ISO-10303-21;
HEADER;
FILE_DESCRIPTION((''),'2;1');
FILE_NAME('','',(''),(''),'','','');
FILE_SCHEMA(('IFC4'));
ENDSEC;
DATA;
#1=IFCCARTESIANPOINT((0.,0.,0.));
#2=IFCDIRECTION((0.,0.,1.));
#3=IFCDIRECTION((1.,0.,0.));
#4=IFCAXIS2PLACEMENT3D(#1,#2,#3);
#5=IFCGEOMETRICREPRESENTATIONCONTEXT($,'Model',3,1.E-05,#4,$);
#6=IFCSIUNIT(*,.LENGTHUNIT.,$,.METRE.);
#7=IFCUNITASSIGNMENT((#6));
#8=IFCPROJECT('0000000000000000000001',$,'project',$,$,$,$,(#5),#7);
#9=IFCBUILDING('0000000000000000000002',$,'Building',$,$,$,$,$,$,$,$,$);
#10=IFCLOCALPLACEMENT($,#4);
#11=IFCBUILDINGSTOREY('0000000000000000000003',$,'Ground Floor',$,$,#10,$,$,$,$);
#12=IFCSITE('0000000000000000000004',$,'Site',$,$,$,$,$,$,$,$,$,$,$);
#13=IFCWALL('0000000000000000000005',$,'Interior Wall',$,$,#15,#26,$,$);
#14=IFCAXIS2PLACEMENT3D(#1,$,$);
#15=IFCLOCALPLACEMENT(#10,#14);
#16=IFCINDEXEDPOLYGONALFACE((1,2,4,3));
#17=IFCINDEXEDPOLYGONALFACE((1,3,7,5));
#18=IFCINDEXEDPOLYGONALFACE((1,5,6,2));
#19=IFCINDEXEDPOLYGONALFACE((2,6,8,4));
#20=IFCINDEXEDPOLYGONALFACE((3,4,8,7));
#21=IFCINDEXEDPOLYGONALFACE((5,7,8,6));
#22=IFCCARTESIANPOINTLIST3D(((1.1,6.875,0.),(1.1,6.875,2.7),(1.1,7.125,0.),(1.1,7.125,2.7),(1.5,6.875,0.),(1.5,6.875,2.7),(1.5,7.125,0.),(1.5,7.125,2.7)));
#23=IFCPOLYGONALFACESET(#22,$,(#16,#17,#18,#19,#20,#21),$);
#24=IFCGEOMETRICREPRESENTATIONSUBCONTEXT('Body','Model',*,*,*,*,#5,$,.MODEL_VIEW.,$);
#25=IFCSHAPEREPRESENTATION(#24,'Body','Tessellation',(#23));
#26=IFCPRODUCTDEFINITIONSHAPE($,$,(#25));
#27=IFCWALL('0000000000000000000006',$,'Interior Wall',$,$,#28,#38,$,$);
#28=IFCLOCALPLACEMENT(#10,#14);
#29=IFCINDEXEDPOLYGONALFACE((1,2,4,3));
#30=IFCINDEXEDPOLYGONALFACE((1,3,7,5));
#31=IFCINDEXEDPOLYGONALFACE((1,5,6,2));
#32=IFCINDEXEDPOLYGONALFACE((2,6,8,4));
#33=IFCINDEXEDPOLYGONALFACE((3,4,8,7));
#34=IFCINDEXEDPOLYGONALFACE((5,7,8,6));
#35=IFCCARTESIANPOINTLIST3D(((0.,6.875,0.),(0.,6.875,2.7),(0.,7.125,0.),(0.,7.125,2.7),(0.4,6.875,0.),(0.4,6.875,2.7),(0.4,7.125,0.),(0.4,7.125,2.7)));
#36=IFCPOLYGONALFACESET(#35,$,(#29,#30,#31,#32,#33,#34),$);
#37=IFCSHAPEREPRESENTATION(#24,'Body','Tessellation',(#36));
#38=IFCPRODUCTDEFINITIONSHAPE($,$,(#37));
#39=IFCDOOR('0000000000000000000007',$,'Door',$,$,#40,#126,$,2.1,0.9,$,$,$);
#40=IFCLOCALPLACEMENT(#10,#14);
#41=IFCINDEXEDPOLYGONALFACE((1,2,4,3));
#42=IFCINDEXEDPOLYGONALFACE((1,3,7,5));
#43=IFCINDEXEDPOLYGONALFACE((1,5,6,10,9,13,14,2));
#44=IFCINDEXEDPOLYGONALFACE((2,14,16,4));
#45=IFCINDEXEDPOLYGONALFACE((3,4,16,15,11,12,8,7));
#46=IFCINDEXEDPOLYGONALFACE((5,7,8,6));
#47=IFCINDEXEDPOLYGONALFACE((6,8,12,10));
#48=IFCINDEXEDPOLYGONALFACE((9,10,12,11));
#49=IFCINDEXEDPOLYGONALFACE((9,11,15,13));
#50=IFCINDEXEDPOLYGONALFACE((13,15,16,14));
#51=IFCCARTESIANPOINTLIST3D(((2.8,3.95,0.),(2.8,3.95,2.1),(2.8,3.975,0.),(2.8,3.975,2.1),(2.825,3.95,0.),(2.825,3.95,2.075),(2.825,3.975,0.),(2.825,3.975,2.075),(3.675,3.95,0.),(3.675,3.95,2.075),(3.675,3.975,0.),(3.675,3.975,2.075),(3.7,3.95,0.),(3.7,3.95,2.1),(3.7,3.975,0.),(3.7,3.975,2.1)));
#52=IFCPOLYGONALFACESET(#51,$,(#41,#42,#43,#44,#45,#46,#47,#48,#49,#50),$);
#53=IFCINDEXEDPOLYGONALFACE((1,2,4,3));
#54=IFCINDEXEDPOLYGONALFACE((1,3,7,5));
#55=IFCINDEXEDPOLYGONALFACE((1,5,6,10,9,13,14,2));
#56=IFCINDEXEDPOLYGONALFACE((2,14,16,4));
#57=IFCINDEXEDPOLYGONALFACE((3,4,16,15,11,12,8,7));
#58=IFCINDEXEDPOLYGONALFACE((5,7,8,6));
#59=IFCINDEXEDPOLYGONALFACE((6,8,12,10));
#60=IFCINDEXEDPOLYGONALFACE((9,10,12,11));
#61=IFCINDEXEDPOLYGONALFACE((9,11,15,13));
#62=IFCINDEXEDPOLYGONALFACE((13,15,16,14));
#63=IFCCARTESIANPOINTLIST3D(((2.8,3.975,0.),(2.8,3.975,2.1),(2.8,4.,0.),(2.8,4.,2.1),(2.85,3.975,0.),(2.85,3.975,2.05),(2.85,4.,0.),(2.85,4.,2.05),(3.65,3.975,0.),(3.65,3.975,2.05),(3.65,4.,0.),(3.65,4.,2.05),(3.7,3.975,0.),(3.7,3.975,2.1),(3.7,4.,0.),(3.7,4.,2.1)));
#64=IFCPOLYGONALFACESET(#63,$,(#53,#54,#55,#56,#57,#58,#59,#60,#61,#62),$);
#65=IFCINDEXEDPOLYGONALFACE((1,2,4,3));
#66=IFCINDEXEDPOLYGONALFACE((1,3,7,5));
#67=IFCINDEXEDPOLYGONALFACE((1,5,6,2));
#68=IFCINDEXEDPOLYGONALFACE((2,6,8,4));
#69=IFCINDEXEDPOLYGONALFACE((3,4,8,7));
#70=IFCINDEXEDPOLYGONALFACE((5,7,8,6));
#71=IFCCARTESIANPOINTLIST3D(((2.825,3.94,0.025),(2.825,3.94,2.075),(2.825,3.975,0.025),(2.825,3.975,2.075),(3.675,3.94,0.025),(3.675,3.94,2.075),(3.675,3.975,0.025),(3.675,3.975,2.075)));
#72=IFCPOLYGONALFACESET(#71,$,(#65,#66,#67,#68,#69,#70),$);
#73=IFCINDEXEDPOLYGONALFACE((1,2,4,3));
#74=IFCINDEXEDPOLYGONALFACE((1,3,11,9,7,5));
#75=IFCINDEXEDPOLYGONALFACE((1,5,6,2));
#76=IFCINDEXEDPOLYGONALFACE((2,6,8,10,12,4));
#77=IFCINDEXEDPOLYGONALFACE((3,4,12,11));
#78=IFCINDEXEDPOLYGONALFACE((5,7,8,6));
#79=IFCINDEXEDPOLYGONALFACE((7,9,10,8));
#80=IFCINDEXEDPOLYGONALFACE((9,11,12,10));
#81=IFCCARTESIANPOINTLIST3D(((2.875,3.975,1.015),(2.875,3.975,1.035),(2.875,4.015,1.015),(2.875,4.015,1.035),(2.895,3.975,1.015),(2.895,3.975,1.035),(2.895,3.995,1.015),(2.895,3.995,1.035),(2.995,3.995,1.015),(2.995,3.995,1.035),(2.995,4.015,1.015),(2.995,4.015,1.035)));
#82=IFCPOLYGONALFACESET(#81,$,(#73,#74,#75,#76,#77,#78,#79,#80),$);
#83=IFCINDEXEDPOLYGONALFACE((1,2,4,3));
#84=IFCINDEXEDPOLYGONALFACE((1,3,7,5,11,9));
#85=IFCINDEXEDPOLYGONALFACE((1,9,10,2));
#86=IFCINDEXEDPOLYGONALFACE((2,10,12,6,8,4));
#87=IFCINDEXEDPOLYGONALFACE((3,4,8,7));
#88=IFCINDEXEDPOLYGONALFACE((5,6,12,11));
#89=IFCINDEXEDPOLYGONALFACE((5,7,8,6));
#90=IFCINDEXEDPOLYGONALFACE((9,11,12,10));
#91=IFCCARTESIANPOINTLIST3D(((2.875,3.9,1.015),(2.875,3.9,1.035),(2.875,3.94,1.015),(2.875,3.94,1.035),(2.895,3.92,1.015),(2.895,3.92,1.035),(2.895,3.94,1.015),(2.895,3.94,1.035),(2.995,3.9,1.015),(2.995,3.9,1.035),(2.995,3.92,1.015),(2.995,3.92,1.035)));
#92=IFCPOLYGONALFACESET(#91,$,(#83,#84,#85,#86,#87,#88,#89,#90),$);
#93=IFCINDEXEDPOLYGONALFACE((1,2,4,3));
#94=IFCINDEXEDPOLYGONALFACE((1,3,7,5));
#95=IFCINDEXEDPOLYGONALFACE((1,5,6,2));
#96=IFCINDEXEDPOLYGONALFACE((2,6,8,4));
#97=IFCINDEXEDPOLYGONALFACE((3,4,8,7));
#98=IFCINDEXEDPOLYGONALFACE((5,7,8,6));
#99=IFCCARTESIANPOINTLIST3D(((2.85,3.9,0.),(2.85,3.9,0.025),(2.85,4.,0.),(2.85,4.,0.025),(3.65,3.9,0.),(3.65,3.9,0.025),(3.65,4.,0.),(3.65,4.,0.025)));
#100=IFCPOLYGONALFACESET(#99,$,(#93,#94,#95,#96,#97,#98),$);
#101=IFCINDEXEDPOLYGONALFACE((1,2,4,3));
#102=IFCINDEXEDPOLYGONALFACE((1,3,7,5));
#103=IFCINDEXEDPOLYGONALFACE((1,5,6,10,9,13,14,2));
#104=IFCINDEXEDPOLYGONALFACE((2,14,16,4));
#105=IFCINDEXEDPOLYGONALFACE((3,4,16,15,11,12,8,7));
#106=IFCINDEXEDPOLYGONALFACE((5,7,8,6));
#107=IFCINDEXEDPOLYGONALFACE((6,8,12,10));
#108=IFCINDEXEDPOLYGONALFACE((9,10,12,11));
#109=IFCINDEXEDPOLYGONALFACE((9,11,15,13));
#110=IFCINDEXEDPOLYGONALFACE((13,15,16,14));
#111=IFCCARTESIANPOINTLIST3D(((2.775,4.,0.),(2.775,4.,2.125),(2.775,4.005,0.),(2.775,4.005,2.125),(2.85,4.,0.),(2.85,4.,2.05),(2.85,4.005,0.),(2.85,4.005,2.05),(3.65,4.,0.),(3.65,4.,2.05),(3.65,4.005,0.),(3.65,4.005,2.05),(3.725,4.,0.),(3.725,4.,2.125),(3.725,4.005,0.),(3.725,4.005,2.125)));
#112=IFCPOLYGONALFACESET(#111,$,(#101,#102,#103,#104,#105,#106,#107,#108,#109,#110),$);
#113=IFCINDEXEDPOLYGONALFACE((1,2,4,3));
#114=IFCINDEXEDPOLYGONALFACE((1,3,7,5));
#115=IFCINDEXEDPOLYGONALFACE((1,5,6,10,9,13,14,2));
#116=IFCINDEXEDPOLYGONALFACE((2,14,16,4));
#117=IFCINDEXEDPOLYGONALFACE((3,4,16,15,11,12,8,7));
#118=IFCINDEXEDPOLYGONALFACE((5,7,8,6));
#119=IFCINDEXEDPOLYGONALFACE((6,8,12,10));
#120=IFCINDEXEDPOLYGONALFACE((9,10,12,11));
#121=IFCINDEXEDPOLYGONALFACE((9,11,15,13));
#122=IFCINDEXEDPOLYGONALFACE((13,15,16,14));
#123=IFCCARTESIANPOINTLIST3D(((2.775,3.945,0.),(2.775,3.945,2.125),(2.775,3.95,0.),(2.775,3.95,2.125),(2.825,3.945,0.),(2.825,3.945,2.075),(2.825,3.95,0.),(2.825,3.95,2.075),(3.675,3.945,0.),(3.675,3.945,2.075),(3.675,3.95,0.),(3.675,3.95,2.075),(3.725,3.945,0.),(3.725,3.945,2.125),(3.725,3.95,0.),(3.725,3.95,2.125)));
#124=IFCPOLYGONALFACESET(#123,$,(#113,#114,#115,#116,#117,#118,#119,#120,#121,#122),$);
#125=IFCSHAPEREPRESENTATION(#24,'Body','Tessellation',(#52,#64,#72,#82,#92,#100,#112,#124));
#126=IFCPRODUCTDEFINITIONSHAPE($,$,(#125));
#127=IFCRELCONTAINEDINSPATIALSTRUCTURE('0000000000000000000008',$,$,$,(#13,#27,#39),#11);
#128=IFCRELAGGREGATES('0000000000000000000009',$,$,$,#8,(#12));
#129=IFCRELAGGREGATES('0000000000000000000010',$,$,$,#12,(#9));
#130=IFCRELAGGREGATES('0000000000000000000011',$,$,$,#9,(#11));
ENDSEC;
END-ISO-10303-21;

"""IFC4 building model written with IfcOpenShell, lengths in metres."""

from ifc_helpers import new_model, si_unit, frame, origin_with_axes, place, context, subcontext, project, spatial, line, indexed_curve, outline, extrude, element, save


model = new_model("IFC4")

# Units and contexts
model_context = context("Model", 3, precision=1e-05, world=origin_with_axes())
body_context = subcontext(model_context, "Body", "Model", "MODEL_VIEW")
ifc_project = project(units=[si_unit("LENGTHUNIT", "METRE")], contexts=[model_context])

# Site, building, storey
site = spatial("IfcSite", under=ifc_project, Name="Site")
building = spatial("IfcBuilding", under=site, Name="Building")
storey_placement = place(None, origin_with_axes())
storey = spatial("IfcBuildingStorey", under=building, at=storey_placement, Name="Ground Floor")

# Walls
for number, where, z_axis, x_axis, name in (
    (1, (1.5, 7.0, 0.0), (0.0, 0.0, 1.0), (-1.0, 0.0, 0.0), "Interior Wall"),
    (2, (0.4, 7.0, 0.0), (0.0, 0.0, 1.0), (-1.0, 0.0, 0.0), "Interior Wall"),
):
    element("IfcWall", number, at=place(storey_placement, frame(where, z_axis=z_axis, x_axis=x_axis)), inside=storey, Name=name, context=body_context, shape_type="SweptSolid", body=[
        extrude(outline(indexed_curve([(0.0, 0.0), (0.0, 0.25), (0.4, 0.25), (0.4, 0.0), (0.0, 0.0)], self_intersect=False)), frame((0.0, -0.125, 0.0), z_axis=(0.0, 0.0, 1.0), x_axis=(1.0, 0.0, 0.0)), (0.0, 0.0, 1.0), 2.7),
    ])

# Door
door_1_placement = place(storey_placement, frame((3.7, 4.0, 0.0), z_axis=(0.0, 0.0, 1.0), x_axis=(-1.0, 0.0, 0.0)))
element("IfcDoor", 3, at=door_1_placement, inside=storey, Name="Door", OverallHeight=2.1, OverallWidth=0.9, context=body_context, shape_type="SweptSolid", body=[
    extrude(outline(indexed_curve([(0.0, 0.0), (0.0, 2.1), (0.9, 2.1), (0.9, 0.0), (0.875, 0.0), (0.875, 2.075), (0.025, 2.075), (0.025, 0.0)], segments=[line(1, 2, 3, 4, 5, 6, 7, 8, 1)])), frame((0.0, 0.025, 0.0), z_axis=(0.0, -1.0, 0.0), x_axis=(1.0, 0.0, 0.0)), (0.0, 0.0, -1.0), 0.025),
    extrude(outline(indexed_curve([(0.0, 0.0), (0.0, 2.1), (0.9, 2.1), (0.9, 0.0), (0.85, 0.0), (0.85, 2.05), (0.05, 2.05), (0.05, 0.0)], segments=[line(1, 2, 3, 4, 5, 6, 7, 8, 1)])), frame((0.0, 0.0, 0.0), z_axis=(0.0, -1.0, 0.0), x_axis=(1.0, 0.0, 0.0)), (0.0, 0.0, -1.0), 0.025),
    extrude(outline(indexed_curve([(0.0, 0.0), (0.85, 0.0), (0.85, 0.035), (0.0, 0.035)], segments=[line(1, 2, 3, 4, 1)])), frame((0.025, 0.025, 0.025), z_axis=(0.0, 0.0, 1.0), x_axis=(1.0, 0.0, 0.0)), (0.0, 0.0, 1.0), 2.05),
    extrude(outline(indexed_curve([(0.0, 0.0), (0.0, -0.04), (-0.12, -0.04), (-0.12, -0.02), (-0.02, -0.02), (-0.02, 0.0)], segments=[line(1, 2, 3, 4, 5, 6, 1)])), frame((0.825, 0.025, 1.015), z_axis=(0.0, 0.0, 1.0), x_axis=(1.0, 0.0, 0.0)), (0.0, 0.0, 1.0), 0.02),
    extrude(outline(indexed_curve([(0.0, 0.0), (0.0, 0.04), (-0.12, 0.04), (-0.12, 0.02), (-0.02, 0.02), (-0.02, 0.0)], segments=[line(1, 2, 3, 4, 5, 6, 1)])), frame((0.825, 0.06, 1.015), z_axis=(0.0, 0.0, 1.0), x_axis=(1.0, 0.0, 0.0)), (0.0, 0.0, 1.0), 0.02),
    extrude(outline(indexed_curve([(0.0, 0.0), (0.8, 0.0), (0.8, 0.1), (0.0, 0.1)], segments=[line(1, 2, 3, 4, 1)])), frame((0.05, 0.0, 0.0), z_axis=(0.0, 0.0, 1.0), x_axis=(1.0, 0.0, 0.0)), (0.0, 0.0, 1.0), 0.025),
    extrude(outline(indexed_curve([(0.0, 0.0), (0.0, 2.125), (0.95, 2.125), (0.95, 0.0), (0.875, 0.0), (0.875, 2.05), (0.075, 2.05), (0.075, 0.0)], segments=[line(1, 2, 3, 4, 5, 6, 7, 8, 1)])), frame((-0.025, -0.005, 0.0), z_axis=(0.0, -1.0, 0.0), x_axis=(1.0, 0.0, 0.0)), (0.0, 0.0, -1.0), 0.005),
    extrude(outline(indexed_curve([(0.0, 0.0), (0.0, 2.125), (0.95, 2.125), (0.95, 0.0), (0.9, 0.0), (0.9, 2.075), (0.05, 2.075), (0.05, 0.0)], segments=[line(1, 2, 3, 4, 5, 6, 7, 8, 1)])), frame((-0.025, 0.05, 0.0), z_axis=(0.0, -1.0, 0.0), x_axis=(1.0, 0.0, 0.0)), (0.0, 0.0, -1.0), 0.005),
])

save(model, "model.ifc")
